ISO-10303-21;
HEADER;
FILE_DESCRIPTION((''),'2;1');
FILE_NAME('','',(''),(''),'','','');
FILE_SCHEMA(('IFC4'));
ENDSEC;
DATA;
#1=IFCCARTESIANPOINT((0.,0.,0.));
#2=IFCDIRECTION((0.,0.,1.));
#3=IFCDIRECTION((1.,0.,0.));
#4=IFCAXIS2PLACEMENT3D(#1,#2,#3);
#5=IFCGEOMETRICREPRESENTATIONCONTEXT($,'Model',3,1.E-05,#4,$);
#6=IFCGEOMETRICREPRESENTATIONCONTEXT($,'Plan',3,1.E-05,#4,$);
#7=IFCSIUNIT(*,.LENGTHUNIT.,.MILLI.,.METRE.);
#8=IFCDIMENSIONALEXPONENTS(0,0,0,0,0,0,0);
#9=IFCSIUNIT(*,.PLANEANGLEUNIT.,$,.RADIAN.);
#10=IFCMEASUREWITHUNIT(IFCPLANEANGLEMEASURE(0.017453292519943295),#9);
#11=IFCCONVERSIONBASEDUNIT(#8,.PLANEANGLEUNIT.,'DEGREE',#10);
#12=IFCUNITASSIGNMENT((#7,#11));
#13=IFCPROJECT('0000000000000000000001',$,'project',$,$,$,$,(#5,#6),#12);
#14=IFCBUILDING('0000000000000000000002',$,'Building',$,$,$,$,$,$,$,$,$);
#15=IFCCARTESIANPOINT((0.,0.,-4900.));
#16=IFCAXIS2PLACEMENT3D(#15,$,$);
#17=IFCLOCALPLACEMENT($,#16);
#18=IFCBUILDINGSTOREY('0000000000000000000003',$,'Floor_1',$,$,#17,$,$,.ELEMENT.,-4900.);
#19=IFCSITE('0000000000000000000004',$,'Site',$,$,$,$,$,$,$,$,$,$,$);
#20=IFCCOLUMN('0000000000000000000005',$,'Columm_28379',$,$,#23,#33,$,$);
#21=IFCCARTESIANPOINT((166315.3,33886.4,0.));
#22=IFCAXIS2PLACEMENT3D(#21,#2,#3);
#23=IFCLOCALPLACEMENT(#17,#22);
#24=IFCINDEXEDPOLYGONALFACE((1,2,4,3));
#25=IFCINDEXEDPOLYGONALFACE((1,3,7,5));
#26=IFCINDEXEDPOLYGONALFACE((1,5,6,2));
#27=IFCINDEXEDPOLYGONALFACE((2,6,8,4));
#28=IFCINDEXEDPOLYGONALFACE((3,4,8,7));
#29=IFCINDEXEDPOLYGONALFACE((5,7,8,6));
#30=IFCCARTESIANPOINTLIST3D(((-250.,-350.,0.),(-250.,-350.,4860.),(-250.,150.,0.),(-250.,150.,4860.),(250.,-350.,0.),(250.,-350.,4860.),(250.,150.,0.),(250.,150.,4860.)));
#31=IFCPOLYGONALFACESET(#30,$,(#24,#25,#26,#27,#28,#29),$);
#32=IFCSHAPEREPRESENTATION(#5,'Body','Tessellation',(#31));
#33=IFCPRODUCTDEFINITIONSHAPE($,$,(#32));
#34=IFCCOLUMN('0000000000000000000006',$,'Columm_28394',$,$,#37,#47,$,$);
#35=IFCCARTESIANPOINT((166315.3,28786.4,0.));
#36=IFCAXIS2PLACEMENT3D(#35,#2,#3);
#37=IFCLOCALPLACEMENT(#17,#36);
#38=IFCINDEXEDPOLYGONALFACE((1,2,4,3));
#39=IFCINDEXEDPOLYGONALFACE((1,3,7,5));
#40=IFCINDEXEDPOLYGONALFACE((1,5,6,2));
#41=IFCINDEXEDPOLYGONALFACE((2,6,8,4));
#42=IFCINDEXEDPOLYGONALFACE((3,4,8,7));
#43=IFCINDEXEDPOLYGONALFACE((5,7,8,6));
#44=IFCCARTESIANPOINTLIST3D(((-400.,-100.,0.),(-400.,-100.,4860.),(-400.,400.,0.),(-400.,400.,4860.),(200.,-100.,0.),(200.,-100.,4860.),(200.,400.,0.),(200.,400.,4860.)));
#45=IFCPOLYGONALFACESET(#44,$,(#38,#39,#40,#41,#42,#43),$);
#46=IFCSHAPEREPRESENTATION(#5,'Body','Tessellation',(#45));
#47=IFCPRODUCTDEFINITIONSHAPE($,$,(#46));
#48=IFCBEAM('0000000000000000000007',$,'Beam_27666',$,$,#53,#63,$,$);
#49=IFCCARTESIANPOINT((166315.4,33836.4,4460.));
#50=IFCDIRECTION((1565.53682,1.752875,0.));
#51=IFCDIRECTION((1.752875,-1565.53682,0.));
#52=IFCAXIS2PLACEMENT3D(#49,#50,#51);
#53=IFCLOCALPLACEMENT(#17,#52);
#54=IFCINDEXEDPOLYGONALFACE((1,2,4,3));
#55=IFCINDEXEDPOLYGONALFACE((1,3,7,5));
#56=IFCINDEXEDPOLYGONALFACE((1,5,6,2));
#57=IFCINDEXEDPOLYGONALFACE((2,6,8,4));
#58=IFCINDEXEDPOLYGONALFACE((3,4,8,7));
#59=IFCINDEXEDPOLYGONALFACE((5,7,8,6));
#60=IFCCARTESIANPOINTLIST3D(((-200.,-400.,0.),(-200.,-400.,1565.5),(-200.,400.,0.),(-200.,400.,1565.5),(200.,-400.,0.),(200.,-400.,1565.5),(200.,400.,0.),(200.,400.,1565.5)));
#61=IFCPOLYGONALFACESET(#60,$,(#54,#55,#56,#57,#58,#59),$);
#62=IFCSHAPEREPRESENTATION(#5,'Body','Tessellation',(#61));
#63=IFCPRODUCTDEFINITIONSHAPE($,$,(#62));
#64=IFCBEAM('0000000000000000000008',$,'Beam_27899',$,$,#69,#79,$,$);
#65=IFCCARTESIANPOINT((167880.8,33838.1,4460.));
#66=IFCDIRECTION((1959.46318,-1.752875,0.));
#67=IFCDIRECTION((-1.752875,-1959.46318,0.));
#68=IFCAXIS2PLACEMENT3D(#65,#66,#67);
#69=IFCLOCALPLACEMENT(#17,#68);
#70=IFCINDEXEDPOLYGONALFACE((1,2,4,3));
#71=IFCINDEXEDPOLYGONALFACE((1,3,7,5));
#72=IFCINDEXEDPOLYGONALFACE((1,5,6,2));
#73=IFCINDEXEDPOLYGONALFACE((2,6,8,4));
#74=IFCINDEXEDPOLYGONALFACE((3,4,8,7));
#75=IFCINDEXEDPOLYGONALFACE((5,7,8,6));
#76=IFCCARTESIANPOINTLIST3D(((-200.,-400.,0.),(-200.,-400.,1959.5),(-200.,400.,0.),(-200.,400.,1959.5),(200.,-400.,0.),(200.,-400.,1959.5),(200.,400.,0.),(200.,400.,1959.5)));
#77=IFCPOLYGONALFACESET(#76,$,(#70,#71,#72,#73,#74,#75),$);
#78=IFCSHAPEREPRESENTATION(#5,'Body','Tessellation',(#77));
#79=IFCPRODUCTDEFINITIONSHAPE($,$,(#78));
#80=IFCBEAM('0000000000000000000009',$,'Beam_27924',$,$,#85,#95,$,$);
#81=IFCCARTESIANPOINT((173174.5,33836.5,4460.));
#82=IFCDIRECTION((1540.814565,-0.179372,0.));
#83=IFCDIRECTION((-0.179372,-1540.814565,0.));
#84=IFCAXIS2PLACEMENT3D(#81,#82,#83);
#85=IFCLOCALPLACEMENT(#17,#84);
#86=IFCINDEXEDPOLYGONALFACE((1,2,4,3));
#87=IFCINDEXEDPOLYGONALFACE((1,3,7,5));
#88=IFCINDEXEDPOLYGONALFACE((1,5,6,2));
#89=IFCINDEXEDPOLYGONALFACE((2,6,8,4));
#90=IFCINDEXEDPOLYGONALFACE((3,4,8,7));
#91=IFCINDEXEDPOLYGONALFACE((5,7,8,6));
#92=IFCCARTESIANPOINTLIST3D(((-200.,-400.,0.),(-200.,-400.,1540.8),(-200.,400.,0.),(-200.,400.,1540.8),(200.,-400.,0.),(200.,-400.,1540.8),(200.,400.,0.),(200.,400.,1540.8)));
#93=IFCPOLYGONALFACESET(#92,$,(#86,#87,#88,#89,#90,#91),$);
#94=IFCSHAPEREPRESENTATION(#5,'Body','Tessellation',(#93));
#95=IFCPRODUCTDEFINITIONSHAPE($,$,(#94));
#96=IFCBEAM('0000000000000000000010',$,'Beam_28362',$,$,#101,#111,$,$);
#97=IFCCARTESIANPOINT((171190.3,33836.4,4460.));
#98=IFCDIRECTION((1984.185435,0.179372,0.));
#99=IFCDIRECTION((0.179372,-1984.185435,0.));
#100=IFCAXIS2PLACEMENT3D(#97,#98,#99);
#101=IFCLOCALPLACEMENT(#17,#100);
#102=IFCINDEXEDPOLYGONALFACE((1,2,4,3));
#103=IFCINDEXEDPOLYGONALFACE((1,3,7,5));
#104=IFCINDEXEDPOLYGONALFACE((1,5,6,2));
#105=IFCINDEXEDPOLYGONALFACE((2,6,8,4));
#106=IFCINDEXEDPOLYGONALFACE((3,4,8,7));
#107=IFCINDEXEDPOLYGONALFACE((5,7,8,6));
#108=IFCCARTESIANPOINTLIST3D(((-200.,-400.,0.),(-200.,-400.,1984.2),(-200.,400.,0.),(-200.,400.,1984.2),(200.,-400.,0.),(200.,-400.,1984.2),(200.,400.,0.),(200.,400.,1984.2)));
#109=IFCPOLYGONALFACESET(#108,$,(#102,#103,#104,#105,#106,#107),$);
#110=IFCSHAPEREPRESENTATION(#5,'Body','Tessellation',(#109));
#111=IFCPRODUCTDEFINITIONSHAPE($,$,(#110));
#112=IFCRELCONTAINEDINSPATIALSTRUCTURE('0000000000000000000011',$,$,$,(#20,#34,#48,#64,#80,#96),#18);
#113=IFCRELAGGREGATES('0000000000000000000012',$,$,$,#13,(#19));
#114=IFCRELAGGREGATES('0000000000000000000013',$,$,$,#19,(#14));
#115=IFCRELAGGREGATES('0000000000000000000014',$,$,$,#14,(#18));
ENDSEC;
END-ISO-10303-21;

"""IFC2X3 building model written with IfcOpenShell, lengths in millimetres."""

from ifc_helpers import new_model, entity, si_unit, converted_unit, frame, origin_with_axes, origin_2d, place, context, project, spatial, rectangle, extrude, element, save


model = new_model("IFC2X3")

# Units and contexts
model_context = context("Model", 3, precision=1e-05, world=origin_with_axes())
plan_context = context("Plan", 3, precision=1e-05, world=origin_with_axes())
ifc_project = project(units=[si_unit("LENGTHUNIT", "METRE", prefix="MILLI"), converted_unit("PLANEANGLEUNIT", "DEGREE", entity("IfcPlaneAngleMeasure", 0.017453292519943295), si_unit("PLANEANGLEUNIT", "RADIAN"), dimensions=[0, 0, 0, 0, 0, 0, 0])], contexts=[model_context, plan_context])

# Site, building, storey
site = spatial("IfcSite", under=ifc_project, Name="Site")
building = spatial("IfcBuilding", under=site, Name="Building")
storey_placement = place(None, frame((0.0, 0.0, -4900.0)))
storey = spatial("IfcBuildingStorey", under=building, at=storey_placement, Name="Floor_1", CompositionType="ELEMENT", Elevation=-4900.0)

# Columns
column_1_placement = place(storey_placement, frame((166315.3, 33886.4, 0.0), z_axis=(0.0, 0.0, 1.0), x_axis=(1.0, 0.0, 0.0)))
element("IfcColumn", 1, at=column_1_placement, inside=storey, Name="Columm_28379", context=model_context, shape_type="SweptSolid", body=[
    extrude(rectangle(XDim=500.0, YDim=500.0, at=origin_2d()), frame((0.0, -100.0, 0.0), z_axis=(0.0, 0.0, 1.0), x_axis=(1.0, 0.0, 0.0)), (0.0, 0.0, 1.0), 4860.0),
])
column_2_placement = place(storey_placement, frame((166315.3, 28786.4, 0.0), z_axis=(0.0, 0.0, 1.0), x_axis=(1.0, 0.0, 0.0)))
element("IfcColumn", 2, at=column_2_placement, inside=storey, Name="Columm_28394", context=model_context, shape_type="SweptSolid", body=[
    extrude(rectangle(XDim=600.0, YDim=500.0, at=origin_2d()), frame((-100.0, 150.0, 0.0), z_axis=(0.0, 0.0, 1.0), x_axis=(1.0, 0.0, 0.0)), (0.0, 0.0, 1.0), 4860.0),
])

# Beams
beam_1_placement = place(storey_placement, frame((166315.4, 33836.4, 4460.0), z_axis=(1565.53682, 1.752875, 0.0), x_axis=(1.752875, -1565.53682, 0.0)))
element("IfcBeam", 3, at=beam_1_placement, inside=storey, Name="Beam_27666", context=model_context, shape_type="SweptSolid", body=[
    extrude(rectangle(XDim=400.0, YDim=800.0, at=origin_2d()), origin_with_axes(), (0.0, 0.0, 1.0), 1565.5),
])
beam_2_placement = place(storey_placement, frame((167880.8, 33838.1, 4460.0), z_axis=(1959.46318, -1.752875, 0.0), x_axis=(-1.752875, -1959.46318, 0.0)))
element("IfcBeam", 4, at=beam_2_placement, inside=storey, Name="Beam_27899", context=model_context, shape_type="SweptSolid", body=[
    extrude(rectangle(XDim=400.0, YDim=800.0, at=origin_2d()), origin_with_axes(), (0.0, 0.0, 1.0), 1959.5),
])
beam_3_placement = place(storey_placement, frame((173174.5, 33836.5, 4460.0), z_axis=(1540.814565, -0.179372, 0.0), x_axis=(-0.179372, -1540.814565, 0.0)))
element("IfcBeam", 5, at=beam_3_placement, inside=storey, Name="Beam_27924", context=model_context, shape_type="SweptSolid", body=[
    extrude(rectangle(XDim=400.0, YDim=800.0, at=origin_2d()), origin_with_axes(), (0.0, 0.0, 1.0), 1540.8),
])
beam_4_placement = place(storey_placement, frame((171190.3, 33836.4, 4460.0), z_axis=(1984.185435, 0.179372, 0.0), x_axis=(0.179372, -1984.185435, 0.0)))
element("IfcBeam", 6, at=beam_4_placement, inside=storey, Name="Beam_28362", context=model_context, shape_type="SweptSolid", body=[
    extrude(rectangle(XDim=400.0, YDim=800.0, at=origin_2d()), origin_with_axes(), (0.0, 0.0, 1.0), 1984.2),
])

save(model, "model.ifc")
